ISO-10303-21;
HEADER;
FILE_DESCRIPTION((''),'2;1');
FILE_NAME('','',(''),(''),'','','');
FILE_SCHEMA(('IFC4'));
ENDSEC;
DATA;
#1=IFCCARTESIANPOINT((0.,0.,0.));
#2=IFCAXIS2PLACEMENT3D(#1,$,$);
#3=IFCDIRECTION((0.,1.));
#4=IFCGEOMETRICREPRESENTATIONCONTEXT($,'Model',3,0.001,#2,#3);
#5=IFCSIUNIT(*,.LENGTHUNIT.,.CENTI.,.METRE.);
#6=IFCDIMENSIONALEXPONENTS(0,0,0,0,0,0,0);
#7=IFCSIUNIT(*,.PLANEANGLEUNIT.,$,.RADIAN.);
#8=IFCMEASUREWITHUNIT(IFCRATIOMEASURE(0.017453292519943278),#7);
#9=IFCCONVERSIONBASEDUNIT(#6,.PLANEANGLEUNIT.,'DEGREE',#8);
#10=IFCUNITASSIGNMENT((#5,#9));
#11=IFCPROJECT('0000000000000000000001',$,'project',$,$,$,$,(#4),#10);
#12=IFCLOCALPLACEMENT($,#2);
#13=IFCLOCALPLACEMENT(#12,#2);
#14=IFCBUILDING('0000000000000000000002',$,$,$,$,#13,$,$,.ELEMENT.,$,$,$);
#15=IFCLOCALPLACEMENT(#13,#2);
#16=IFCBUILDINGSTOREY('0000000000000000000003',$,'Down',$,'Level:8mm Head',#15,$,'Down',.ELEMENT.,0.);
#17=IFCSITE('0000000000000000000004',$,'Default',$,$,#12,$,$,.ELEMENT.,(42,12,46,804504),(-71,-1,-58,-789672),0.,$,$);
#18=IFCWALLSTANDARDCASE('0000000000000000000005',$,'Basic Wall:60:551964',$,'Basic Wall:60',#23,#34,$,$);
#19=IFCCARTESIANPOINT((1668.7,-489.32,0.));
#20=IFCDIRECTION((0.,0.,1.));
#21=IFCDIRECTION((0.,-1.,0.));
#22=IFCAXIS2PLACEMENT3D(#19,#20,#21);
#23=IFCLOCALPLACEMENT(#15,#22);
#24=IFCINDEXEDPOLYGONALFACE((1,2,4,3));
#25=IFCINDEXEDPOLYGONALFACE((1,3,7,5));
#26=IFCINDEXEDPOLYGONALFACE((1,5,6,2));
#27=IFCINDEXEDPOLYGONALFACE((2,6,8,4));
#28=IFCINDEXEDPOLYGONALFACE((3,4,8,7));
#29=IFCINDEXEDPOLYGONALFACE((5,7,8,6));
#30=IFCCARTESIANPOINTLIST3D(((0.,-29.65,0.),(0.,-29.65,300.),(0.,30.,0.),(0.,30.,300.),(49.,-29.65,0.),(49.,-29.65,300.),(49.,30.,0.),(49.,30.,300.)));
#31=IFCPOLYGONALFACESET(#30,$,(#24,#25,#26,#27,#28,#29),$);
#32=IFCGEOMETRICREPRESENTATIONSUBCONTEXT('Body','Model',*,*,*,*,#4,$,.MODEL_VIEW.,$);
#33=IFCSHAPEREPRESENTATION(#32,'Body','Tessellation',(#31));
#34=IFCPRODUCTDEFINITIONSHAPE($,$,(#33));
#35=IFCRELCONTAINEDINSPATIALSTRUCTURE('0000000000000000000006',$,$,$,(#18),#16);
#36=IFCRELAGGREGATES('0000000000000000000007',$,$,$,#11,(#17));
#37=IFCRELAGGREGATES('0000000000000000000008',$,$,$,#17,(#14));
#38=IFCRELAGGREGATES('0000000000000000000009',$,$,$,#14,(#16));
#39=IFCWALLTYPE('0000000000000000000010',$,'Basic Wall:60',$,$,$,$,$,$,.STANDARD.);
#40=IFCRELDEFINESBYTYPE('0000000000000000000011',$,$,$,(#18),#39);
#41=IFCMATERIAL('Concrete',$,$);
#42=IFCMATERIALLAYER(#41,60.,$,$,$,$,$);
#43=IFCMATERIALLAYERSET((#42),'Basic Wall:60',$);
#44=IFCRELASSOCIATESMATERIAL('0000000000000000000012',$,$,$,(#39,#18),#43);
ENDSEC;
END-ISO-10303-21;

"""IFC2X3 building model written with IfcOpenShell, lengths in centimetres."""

from ifc_helpers import new_model, entity, si_unit, converted_unit, direction, frame, frame_2d, origin, place, context, subcontext, project, spatial, polyline, rectangle, extrude, clip, bounded_halfspace, material, layer, layer_set, layer_usage, type_object, element, save


model = new_model("IFC2X3")

# Units and contexts
model_context = context("Model", 3, precision=0.001, world=origin(), true_north=direction((0.0, 1.0)))
body_context = subcontext(model_context, "Body", "Model", "MODEL_VIEW")
ifc_project = project(units=[si_unit("LENGTHUNIT", "METRE", prefix="CENTI"), converted_unit("PLANEANGLEUNIT", "DEGREE", entity("IfcRatioMeasure", 0.017453292519943278), si_unit("PLANEANGLEUNIT", "RADIAN"), dimensions=[0, 0, 0, 0, 0, 0, 0])], contexts=[model_context])

# Site, building, storey
site_placement = place(None, origin())
site = spatial("IfcSite", under=ifc_project, at=site_placement, Name="Default", CompositionType="ELEMENT", RefLatitude=(42, 12, 46, 804504), RefLongitude=(-71, -1, -58, -789672), RefElevation=0.0)
building_placement = place(site_placement, origin())
building = spatial("IfcBuilding", under=site, at=building_placement, CompositionType="ELEMENT")
storey_placement = place(building_placement, origin())
storey = spatial("IfcBuildingStorey", under=building, at=storey_placement, Name="Down", ObjectType="Level:8mm Head", LongName="Down", CompositionType="ELEMENT", Elevation=0.0)

# Shared definitions
ifc_material = material(Name="Concrete")

# Wall
ifc_layer_1 = layer(ifc_material, 60.0)
ifc_layer_set_1 = layer_set([ifc_layer_1], Name="Basic Wall:60")
ifc_layer_usage_1 = layer_usage(ifc_layer_set_1, "AXIS2", "POSITIVE", -30.0)
wall_type_1 = type_object("IfcWallType", Name="Basic Wall:60", PredefinedType="STANDARD", material=ifc_layer_set_1)
wall_1_placement = place(storey_placement, frame((1668.7, -489.32, 0.0), z_axis=(0.0, 0.0, 1.0), x_axis=(0.0, -1.0, 0.0)))
element("IfcWallStandardCase", 1, at=wall_1_placement, inside=storey, type_object=wall_type_1, material=ifc_layer_usage_1, Name="Basic Wall:60:551964", ObjectType="Basic Wall:60", context=body_context, shape_type="Clipping", body=[
    clip(extrude(rectangle(XDim=49.0, YDim=60.0, at=frame_2d((24.5, 0.0), x_axis=(-1.0, 0.0))), origin(), (0.0, 0.0, 1.0), 300.0), bounded_halfspace(frame((49.0, -29.65, 0.0), z_axis=(0.0, 1.0, 0.0), x_axis=(-1.0, 0.0, 0.0)), True, frame((49.0, -29.65, 0.0), z_axis=(0.0, 1.0, 0.0), x_axis=(-1.0, 0.0, 0.0)), polyline([(0.0, 0.0), (24.0, 0.0), (49.0, 0.0), (49.0, 300.0), (24.0, 300.0), (0.0, 300.0), (0.0, 0.0)]))),
])

save(model, "model.ifc")
